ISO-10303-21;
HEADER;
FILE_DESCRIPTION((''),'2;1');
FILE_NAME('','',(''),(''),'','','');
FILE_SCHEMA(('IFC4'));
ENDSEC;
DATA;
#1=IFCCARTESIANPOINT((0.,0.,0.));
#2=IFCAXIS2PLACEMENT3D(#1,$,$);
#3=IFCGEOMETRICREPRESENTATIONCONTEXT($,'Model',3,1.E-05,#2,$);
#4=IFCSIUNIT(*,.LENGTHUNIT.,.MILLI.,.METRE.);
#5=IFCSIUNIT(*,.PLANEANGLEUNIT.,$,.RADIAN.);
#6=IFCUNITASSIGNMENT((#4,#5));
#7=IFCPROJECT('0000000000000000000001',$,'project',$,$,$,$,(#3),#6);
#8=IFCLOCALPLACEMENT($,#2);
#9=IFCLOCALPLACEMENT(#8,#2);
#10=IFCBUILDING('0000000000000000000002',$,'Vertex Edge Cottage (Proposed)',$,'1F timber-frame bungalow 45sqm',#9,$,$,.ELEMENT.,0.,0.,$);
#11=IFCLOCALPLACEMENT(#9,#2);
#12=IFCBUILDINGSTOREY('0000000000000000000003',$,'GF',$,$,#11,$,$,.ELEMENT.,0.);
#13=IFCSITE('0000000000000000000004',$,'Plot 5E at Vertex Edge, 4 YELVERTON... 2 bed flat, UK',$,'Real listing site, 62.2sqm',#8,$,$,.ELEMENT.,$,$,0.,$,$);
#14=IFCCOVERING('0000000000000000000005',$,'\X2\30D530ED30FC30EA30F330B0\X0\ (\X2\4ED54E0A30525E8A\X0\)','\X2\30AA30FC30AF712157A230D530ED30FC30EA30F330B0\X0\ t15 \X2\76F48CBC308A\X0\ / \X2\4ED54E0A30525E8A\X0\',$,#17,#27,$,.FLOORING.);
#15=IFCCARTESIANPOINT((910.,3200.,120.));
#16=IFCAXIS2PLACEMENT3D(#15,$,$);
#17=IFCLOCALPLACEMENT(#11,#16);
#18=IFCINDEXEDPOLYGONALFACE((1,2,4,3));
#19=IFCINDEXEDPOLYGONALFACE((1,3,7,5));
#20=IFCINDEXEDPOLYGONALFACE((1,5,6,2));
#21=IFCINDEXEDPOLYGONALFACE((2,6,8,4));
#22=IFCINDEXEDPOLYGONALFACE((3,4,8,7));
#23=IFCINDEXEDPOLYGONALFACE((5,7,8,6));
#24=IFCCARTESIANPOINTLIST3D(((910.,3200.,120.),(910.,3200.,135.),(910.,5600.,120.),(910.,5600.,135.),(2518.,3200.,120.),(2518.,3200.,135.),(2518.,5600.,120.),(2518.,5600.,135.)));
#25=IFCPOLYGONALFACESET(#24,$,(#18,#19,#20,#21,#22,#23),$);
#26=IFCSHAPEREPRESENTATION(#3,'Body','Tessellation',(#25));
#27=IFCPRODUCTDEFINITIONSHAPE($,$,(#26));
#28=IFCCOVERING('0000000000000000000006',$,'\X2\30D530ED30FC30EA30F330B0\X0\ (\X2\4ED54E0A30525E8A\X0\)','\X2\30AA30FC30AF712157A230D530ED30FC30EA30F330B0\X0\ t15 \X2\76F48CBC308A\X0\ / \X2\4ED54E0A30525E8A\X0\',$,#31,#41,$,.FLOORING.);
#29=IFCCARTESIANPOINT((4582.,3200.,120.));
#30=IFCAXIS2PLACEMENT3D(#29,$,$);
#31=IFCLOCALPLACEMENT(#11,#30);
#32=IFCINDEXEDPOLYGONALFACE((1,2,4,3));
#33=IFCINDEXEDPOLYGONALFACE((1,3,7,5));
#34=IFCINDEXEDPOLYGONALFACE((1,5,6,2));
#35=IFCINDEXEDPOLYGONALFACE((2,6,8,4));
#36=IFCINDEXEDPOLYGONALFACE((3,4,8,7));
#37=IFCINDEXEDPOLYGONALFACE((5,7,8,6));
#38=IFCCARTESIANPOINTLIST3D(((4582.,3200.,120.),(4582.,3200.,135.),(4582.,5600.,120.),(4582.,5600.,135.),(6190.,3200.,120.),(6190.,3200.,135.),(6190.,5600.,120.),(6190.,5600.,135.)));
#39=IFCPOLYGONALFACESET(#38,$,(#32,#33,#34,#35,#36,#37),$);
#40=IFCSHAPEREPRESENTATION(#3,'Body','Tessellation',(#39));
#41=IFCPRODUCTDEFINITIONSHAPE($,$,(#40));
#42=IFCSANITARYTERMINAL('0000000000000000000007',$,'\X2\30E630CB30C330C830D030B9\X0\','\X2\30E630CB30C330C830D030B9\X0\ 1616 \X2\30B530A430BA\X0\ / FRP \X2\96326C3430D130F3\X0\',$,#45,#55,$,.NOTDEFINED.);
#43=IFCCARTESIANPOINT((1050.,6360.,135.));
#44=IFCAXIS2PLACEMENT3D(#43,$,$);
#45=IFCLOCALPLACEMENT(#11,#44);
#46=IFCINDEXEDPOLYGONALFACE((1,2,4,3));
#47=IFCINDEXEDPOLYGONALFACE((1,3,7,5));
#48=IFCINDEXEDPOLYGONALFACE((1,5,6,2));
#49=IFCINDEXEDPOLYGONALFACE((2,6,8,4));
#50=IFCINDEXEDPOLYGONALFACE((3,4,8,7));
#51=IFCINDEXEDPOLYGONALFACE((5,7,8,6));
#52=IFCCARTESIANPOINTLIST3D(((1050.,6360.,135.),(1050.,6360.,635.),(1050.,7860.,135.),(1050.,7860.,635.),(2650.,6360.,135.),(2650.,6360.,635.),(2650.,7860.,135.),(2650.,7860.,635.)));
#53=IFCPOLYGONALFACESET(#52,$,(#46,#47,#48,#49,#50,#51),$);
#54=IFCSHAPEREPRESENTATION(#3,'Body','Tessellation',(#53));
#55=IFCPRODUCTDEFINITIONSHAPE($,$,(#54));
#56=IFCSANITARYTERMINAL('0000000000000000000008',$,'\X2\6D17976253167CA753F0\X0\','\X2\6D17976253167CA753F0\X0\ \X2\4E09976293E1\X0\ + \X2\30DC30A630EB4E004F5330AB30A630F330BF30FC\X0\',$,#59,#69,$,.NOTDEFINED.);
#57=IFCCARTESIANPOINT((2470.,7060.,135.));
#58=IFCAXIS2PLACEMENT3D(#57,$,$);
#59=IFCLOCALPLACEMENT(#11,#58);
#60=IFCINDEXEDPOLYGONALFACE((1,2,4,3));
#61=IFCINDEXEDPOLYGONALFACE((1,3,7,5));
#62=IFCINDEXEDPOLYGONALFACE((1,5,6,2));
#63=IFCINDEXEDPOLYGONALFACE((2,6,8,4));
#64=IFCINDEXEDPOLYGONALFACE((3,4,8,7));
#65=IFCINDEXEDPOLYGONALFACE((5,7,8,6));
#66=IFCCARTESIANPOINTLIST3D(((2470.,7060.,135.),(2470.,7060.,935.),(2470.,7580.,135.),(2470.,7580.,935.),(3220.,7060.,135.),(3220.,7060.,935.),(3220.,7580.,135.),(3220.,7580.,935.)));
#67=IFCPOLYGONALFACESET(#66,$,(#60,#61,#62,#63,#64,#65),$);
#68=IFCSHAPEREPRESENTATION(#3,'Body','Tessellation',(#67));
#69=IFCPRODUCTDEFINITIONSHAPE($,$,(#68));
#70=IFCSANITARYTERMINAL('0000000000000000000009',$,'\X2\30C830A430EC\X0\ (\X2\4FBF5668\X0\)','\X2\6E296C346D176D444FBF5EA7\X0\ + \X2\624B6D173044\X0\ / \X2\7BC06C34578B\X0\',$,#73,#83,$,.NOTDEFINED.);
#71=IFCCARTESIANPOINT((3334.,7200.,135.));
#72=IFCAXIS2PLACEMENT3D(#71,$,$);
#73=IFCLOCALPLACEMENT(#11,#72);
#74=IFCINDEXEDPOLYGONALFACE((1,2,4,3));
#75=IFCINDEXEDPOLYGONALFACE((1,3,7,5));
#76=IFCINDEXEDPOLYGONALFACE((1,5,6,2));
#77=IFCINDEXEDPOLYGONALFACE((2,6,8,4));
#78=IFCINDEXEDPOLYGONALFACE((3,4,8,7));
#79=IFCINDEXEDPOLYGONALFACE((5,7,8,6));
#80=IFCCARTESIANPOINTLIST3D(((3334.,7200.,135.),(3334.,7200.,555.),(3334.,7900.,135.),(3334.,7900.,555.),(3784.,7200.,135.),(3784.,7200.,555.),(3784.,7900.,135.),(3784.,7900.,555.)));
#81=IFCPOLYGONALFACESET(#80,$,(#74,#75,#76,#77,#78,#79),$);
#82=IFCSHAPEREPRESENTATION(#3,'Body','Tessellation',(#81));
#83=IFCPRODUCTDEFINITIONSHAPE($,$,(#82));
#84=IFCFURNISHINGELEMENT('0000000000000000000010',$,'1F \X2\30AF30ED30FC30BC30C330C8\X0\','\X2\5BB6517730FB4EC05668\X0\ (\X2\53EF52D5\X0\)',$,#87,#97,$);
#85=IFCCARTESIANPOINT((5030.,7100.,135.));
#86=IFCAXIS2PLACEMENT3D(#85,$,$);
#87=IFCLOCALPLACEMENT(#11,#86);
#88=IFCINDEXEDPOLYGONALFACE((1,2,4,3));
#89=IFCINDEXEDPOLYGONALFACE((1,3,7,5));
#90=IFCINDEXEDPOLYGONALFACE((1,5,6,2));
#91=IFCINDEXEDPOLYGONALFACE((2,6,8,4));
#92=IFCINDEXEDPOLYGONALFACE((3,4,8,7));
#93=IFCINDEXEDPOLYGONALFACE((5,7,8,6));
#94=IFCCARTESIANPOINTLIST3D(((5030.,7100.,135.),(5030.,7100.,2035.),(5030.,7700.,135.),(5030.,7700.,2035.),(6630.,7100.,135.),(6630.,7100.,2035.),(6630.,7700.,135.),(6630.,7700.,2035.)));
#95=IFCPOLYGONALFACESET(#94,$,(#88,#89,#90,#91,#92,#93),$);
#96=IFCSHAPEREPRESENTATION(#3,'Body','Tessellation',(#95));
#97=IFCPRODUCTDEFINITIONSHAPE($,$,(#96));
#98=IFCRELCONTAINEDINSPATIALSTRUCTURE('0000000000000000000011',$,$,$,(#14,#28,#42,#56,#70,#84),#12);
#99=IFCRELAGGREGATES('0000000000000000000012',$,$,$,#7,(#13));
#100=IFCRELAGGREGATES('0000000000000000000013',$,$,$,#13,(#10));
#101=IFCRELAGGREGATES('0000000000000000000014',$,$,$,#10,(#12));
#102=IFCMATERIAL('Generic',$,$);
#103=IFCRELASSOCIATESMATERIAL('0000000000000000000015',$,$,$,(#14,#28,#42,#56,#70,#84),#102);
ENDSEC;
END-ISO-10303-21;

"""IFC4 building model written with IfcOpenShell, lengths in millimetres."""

from ifc_helpers import new_model, si_unit, frame, frame_2d, origin, place, context, project, spatial, rectangle, extrude, material, element, save


model = new_model("IFC4")

# Units and contexts
model_context = context("Model", 3, precision=1e-05, world=origin())
ifc_project = project(units=[si_unit("LENGTHUNIT", "METRE", prefix="MILLI"), si_unit("PLANEANGLEUNIT", "RADIAN")], contexts=[model_context])

# Site, building, storey
site_placement = place(None, origin())
site = spatial("IfcSite", under=ifc_project, at=site_placement, Name="Plot 5E at Vertex Edge, 4 YELVERTON... 2 bed flat, UK", ObjectType="Real listing site, 62.2sqm", CompositionType="ELEMENT", RefElevation=0.0)
building_placement = place(site_placement, origin())
building = spatial("IfcBuilding", under=site, at=building_placement, Name="Vertex Edge Cottage (Proposed)", ObjectType="1F timber-frame bungalow 45sqm", CompositionType="ELEMENT", ElevationOfRefHeight=0.0, ElevationOfTerrain=0.0)
storey_placement = place(building_placement, origin())
storey = spatial("IfcBuildingStorey", under=building, at=storey_placement, Name="GF", CompositionType="ELEMENT", Elevation=0.0)

# Coverings
ifc_material_1 = material(Name="Generic")
covering_1_placement = place(storey_placement, frame((910.0, 3200.0, 120.0)))
element("IfcCovering", 1, at=covering_1_placement, inside=storey, material=ifc_material_1, Name="フローリング (仕上げ床)", Description="オーク無垢フローリング t15 直貼り / 仕上げ床", PredefinedType="FLOORING", context=model_context, shape_type="SweptSolid", body=[
    extrude(rectangle(XDim=1608.0, YDim=2400.0, at=frame_2d((804.0, 1200.0))), frame((910.0, 3200.0, 120.0)), (0.0, 0.0, 1.0), 15.0),
])
covering_2_placement = place(storey_placement, frame((4582.0, 3200.0, 120.0)))
element("IfcCovering", 2, at=covering_2_placement, inside=storey, material=ifc_material_1, Name="フローリング (仕上げ床)", Description="オーク無垢フローリング t15 直貼り / 仕上げ床", PredefinedType="FLOORING", context=model_context, shape_type="SweptSolid", body=[
    extrude(rectangle(XDim=1608.0, YDim=2400.0, at=frame_2d((804.0, 1200.0))), frame((4582.0, 3200.0, 120.0)), (0.0, 0.0, 1.0), 15.0),
])

# Sanitary terminals
sanitary_terminal_1_placement = place(storey_placement, frame((1050.0, 6360.0, 135.0)))
element("IfcSanitaryTerminal", 3, at=sanitary_terminal_1_placement, inside=storey, material=ifc_material_1, Name="ユニットバス", Description="ユニットバス 1616 サイズ / FRP 防水パン", PredefinedType="NOTDEFINED", context=model_context, shape_type="SweptSolid", body=[
    extrude(rectangle(XDim=1600.0, YDim=1500.0, at=frame_2d((800.0, 750.0))), frame((1050.0, 6360.0, 135.0)), (0.0, 0.0, 1.0), 500.0),
])
sanitary_terminal_2_placement = place(storey_placement, frame((2470.0, 7060.0, 135.0)))
element("IfcSanitaryTerminal", 4, at=sanitary_terminal_2_placement, inside=storey, material=ifc_material_1, Name="洗面化粧台", Description="洗面化粧台 三面鏡 + ボウル一体カウンター", PredefinedType="NOTDEFINED", context=model_context, shape_type="SweptSolid", body=[
    extrude(rectangle(XDim=750.0, YDim=520.0, at=frame_2d((375.0, 260.0))), frame((2470.0, 7060.0, 135.0)), (0.0, 0.0, 1.0), 800.0),
])
sanitary_terminal_3_placement = place(storey_placement, frame((3334.0, 7200.0, 135.0)))
element("IfcSanitaryTerminal", 5, at=sanitary_terminal_3_placement, inside=storey, material=ifc_material_1, Name="トイレ (便器)", Description="温水洗浄便座 + 手洗い / 節水型", PredefinedType="NOTDEFINED", context=model_context, shape_type="SweptSolid", body=[
    extrude(rectangle(XDim=450.0, YDim=700.0, at=frame_2d((225.0, 350.0))), frame((3334.0, 7200.0, 135.0)), (0.0, 0.0, 1.0), 420.0),
])

# Furnishing element
furnishing_placement = place(storey_placement, frame((5030.0, 7100.0, 135.0)))
element("IfcFurnishingElement", 6, at=furnishing_placement, inside=storey, material=ifc_material_1, Name="1F クローゼット", Description="家具・什器 (可動)", context=model_context, shape_type="SweptSolid", body=[
    extrude(rectangle(XDim=1600.0, YDim=600.0, at=frame_2d((800.0, 300.0))), frame((5030.0, 7100.0, 135.0)), (0.0, 0.0, 1.0), 1900.0),
])

save(model, "model.ifc")
